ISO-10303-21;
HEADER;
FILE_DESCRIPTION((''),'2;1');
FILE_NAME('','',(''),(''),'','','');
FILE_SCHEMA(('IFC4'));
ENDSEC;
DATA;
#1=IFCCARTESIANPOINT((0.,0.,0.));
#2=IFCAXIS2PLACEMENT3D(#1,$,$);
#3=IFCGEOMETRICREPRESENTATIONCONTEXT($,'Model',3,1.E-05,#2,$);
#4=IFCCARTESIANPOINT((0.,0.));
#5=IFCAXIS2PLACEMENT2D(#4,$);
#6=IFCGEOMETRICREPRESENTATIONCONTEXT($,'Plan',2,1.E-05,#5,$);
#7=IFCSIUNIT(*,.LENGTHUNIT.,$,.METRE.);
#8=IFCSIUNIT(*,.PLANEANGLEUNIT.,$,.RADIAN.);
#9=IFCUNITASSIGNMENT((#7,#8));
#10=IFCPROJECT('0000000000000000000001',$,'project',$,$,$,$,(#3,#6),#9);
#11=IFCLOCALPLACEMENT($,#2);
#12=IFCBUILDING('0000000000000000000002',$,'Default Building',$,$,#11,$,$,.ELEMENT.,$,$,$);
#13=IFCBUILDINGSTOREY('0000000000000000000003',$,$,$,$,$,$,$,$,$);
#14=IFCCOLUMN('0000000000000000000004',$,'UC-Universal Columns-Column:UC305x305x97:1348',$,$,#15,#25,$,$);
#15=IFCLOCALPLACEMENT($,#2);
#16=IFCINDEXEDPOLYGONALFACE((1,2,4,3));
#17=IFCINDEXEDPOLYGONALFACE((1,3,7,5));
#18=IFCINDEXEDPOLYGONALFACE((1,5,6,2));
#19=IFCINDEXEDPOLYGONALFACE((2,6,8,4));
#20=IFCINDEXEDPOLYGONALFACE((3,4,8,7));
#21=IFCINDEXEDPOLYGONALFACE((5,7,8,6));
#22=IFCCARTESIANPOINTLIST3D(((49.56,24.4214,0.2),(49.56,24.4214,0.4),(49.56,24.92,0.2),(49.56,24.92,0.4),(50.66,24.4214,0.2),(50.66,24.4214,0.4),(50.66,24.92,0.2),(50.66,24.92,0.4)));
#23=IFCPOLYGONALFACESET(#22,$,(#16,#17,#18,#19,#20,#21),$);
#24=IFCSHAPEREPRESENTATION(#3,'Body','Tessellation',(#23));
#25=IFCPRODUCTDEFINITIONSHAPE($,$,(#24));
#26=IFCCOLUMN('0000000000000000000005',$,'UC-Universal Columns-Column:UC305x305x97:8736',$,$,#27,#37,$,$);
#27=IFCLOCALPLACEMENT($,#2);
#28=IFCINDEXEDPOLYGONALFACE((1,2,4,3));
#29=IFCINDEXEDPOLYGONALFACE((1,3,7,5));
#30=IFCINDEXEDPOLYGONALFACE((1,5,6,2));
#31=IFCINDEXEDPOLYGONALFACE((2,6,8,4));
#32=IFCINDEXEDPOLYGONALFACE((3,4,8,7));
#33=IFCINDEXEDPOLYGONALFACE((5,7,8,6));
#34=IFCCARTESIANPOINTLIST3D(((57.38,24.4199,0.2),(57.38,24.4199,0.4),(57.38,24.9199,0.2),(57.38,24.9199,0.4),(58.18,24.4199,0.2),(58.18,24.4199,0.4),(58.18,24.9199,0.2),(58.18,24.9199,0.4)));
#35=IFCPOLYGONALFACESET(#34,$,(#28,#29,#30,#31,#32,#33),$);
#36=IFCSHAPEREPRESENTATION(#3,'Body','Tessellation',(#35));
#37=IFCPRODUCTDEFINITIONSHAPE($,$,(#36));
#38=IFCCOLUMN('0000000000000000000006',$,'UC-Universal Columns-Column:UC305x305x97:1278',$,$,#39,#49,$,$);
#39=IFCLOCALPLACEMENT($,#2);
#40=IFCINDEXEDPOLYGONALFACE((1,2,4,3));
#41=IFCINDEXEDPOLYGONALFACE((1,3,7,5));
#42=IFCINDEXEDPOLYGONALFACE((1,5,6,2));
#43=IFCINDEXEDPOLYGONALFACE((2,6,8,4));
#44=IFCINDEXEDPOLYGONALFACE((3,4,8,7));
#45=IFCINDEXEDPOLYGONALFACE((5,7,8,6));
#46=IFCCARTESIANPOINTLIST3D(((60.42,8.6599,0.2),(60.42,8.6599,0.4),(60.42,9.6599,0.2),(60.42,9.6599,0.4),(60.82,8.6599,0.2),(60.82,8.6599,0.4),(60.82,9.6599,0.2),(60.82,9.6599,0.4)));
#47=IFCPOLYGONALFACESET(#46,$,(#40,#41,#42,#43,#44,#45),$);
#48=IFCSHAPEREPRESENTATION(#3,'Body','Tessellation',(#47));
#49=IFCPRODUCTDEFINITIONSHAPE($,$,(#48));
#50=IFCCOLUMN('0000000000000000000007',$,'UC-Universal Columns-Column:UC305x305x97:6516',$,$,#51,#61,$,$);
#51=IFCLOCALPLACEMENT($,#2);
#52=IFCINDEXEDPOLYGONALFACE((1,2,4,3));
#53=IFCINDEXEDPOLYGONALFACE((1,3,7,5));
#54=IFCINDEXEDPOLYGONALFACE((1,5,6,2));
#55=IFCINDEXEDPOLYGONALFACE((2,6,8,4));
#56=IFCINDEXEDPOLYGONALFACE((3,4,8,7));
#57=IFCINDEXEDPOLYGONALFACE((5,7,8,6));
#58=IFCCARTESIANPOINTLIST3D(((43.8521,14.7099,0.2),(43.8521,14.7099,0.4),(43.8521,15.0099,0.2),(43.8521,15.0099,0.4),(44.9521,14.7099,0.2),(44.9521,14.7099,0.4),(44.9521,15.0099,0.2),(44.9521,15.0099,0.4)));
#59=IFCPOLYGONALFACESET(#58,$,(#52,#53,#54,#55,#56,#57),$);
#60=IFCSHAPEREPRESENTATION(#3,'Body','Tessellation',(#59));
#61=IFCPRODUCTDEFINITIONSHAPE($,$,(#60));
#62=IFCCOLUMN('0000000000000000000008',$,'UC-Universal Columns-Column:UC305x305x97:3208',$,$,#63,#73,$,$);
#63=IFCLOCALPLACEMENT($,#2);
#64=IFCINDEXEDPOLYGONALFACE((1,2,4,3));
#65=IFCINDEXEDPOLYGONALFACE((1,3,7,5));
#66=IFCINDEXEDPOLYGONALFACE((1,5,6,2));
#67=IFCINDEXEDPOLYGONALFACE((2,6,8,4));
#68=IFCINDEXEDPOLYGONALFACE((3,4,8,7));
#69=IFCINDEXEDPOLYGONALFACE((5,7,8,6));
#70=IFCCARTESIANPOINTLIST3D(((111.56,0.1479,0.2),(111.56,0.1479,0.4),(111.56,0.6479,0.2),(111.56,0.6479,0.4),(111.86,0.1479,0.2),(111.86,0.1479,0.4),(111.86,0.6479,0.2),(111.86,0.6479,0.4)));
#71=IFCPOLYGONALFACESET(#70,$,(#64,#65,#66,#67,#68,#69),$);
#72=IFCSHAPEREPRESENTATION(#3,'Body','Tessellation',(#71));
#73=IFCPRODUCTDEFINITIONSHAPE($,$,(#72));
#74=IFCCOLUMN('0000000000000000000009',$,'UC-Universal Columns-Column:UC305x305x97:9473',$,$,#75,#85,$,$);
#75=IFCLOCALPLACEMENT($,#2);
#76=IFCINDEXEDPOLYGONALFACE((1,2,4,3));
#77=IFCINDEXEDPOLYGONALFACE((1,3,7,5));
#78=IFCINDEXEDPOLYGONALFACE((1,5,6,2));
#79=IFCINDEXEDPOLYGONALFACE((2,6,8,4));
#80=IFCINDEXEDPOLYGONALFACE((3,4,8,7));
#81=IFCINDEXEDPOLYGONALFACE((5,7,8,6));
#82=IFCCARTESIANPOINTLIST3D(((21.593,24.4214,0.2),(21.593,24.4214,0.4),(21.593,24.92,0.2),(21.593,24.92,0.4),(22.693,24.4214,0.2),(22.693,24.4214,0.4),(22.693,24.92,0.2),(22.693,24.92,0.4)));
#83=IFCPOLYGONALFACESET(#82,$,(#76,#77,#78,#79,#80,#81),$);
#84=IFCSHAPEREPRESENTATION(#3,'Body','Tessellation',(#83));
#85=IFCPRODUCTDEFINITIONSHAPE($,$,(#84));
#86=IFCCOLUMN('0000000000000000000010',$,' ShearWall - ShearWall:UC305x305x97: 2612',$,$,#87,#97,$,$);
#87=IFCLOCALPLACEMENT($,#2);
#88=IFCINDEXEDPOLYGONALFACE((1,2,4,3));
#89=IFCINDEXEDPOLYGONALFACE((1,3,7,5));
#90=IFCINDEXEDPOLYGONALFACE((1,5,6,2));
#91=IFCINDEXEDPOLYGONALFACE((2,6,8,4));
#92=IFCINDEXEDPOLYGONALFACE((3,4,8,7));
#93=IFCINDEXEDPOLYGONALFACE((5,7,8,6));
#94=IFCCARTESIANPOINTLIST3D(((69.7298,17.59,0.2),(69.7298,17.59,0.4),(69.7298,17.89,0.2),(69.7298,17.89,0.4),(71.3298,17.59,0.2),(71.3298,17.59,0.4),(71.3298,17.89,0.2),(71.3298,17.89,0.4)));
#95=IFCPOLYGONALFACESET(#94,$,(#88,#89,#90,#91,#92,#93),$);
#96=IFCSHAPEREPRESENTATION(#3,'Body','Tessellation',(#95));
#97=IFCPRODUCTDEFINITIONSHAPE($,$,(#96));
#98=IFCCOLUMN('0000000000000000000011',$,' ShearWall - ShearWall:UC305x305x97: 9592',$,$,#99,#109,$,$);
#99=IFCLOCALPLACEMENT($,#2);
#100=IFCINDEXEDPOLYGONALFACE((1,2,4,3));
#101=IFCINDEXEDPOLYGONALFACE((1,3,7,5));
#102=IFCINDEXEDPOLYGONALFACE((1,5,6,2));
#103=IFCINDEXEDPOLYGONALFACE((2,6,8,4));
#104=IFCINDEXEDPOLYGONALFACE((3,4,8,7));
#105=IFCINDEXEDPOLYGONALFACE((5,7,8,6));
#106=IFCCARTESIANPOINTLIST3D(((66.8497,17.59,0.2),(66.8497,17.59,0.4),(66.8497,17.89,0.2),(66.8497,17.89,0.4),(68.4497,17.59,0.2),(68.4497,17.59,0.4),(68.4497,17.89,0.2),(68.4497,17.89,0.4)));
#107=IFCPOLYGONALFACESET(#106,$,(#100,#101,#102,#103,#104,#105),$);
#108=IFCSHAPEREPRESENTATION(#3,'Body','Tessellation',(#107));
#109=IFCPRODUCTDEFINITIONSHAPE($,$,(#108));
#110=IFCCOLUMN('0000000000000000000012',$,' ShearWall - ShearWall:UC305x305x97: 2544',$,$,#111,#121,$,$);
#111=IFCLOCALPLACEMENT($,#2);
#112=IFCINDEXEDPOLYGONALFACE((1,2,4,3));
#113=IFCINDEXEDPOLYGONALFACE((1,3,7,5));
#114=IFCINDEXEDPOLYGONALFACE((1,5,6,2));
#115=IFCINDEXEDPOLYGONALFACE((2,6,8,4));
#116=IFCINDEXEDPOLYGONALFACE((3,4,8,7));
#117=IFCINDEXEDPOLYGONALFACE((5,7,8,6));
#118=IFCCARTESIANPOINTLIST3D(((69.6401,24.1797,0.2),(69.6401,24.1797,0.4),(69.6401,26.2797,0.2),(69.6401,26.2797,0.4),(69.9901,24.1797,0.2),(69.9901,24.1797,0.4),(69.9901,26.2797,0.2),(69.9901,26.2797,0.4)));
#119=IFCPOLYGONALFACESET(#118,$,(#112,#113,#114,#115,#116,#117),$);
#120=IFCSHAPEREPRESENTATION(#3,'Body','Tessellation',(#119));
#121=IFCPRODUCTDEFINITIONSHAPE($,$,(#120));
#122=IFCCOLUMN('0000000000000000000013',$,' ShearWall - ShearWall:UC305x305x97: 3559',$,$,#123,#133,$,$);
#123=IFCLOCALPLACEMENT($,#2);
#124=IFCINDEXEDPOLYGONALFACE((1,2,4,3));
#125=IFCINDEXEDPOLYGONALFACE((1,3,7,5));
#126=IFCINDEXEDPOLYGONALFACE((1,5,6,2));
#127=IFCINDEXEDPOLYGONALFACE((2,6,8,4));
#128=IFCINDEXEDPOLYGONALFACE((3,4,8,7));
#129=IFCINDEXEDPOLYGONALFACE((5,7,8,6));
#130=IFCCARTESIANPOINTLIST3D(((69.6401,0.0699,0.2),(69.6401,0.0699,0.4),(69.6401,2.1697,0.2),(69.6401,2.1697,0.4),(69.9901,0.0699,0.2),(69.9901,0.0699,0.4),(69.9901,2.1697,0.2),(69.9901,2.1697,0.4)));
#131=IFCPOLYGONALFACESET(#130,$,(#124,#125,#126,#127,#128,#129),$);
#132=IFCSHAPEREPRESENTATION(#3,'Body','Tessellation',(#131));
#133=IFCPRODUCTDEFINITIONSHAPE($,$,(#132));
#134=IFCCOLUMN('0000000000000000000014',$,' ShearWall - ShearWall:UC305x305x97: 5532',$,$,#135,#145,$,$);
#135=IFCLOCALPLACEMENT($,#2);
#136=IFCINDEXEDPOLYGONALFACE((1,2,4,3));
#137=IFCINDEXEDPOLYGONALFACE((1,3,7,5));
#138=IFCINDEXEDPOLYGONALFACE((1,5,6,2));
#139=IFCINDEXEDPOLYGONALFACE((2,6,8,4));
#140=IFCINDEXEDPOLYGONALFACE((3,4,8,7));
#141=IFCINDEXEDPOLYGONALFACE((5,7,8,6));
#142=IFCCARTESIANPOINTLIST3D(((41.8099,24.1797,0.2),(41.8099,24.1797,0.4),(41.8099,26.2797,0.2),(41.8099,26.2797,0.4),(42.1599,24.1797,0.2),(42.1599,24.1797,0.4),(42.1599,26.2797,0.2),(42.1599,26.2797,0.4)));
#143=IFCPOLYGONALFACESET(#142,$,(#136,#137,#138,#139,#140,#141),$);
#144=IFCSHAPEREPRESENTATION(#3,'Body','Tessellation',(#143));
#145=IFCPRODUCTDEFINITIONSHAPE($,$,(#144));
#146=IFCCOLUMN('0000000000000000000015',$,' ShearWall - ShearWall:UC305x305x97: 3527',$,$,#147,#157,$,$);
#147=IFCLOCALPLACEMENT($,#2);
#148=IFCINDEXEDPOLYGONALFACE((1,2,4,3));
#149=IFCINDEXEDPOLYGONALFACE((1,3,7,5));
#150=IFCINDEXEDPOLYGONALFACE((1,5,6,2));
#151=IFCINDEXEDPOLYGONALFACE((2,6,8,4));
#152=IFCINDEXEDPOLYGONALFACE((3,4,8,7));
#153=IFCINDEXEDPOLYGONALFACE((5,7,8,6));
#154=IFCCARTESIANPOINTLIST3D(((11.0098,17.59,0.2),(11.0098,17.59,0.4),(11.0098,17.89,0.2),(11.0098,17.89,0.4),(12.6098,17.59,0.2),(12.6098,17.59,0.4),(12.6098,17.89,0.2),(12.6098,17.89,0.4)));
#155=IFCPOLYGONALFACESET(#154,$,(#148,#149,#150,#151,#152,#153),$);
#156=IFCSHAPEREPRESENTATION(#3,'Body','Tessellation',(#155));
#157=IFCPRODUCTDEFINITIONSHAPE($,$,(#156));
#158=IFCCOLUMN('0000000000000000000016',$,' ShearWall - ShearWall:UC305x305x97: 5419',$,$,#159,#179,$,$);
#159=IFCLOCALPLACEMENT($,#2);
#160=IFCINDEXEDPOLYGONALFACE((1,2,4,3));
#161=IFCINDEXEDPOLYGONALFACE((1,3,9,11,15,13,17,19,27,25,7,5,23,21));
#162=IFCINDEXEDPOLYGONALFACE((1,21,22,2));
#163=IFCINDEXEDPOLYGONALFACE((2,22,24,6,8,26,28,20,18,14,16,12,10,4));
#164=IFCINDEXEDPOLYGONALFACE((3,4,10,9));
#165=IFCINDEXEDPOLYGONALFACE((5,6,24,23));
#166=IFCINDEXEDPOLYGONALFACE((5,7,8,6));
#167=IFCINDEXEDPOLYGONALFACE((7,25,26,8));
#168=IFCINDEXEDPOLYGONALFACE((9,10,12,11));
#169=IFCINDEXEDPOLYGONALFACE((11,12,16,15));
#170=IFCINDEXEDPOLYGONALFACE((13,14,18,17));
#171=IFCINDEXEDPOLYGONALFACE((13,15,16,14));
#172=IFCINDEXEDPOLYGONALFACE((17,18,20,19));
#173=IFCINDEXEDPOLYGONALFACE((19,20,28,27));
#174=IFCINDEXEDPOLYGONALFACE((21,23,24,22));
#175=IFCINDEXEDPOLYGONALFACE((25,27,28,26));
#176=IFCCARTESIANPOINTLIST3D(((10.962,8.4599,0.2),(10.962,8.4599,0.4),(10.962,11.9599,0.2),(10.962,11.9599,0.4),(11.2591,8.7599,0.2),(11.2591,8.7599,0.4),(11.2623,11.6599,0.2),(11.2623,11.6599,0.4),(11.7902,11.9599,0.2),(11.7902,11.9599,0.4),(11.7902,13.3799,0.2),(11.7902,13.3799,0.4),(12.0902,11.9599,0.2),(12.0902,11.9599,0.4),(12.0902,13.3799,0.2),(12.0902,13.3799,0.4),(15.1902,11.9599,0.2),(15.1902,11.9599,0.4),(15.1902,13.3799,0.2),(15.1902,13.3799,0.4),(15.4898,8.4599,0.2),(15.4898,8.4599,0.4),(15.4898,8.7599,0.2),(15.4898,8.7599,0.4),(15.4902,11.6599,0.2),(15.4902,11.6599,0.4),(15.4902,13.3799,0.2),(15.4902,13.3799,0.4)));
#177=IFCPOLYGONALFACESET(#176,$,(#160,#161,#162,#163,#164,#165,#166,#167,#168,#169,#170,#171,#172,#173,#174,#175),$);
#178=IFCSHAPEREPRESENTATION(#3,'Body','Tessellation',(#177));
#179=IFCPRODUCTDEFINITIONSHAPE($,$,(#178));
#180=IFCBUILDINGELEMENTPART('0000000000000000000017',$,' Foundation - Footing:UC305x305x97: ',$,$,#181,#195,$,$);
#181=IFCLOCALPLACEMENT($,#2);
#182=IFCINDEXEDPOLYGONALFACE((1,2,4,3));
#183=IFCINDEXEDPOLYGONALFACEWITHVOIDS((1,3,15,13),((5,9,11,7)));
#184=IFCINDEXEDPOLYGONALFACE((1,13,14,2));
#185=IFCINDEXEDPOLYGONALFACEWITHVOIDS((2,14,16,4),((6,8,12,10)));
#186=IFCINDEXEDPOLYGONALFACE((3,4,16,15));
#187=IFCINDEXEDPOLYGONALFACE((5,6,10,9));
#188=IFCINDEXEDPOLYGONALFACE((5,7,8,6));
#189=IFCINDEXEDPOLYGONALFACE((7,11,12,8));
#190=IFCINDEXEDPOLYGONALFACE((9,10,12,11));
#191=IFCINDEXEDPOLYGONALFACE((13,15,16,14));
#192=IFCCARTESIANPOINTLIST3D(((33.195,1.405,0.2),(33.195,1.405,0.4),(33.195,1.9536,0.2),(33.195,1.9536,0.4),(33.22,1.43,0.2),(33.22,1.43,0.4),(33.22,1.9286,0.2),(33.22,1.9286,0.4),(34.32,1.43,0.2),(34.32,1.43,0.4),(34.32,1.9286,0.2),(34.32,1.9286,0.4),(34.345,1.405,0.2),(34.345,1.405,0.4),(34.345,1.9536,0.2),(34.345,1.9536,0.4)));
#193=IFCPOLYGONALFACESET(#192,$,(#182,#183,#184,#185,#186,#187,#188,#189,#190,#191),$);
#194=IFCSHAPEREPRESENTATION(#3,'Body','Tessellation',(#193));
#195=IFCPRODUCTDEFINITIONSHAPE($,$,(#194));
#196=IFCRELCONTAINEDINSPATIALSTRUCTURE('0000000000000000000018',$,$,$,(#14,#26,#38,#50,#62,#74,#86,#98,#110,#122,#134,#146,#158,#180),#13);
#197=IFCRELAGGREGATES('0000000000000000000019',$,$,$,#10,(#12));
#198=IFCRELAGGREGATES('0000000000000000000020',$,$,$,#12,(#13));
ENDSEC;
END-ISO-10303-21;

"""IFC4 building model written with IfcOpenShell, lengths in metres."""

from ifc_helpers import new_model, si_unit, origin, origin_with_axes, origin_2d, place, context, project, spatial, polyline, outline, extrude, element, save


model = new_model("IFC4")

# Units and contexts
model_context = context("Model", 3, precision=1e-05, world=origin())
plan_context = context("Plan", 2, precision=1e-05, world=origin_2d())
ifc_project = project(units=[si_unit("LENGTHUNIT", "METRE"), si_unit("PLANEANGLEUNIT", "RADIAN")], contexts=[model_context, plan_context])

# Building, storey
building_placement = place(None, origin())
building = spatial("IfcBuilding", under=ifc_project, at=building_placement, Name="Default Building", CompositionType="ELEMENT")
storey = spatial("IfcBuildingStorey", under=building)

# Columns
element("IfcColumn", 1, inside=storey, Name="UC-Universal Columns-Column:UC305x305x97:1348", context=model_context, shape_type="SweptSolid", body=[
    extrude(outline(polyline([(50.66, 24.4214, 0.2), (49.56, 24.4214, 0.2), (49.56, 24.92, 0.2), (50.66, 24.92, 0.2), (50.66, 24.4214, 0.2)])), None, (0.0, 0.0, 1.0), 0.2),
])
element("IfcColumn", 2, inside=storey, Name="UC-Universal Columns-Column:UC305x305x97:8736", context=model_context, shape_type="SweptSolid", body=[
    extrude(outline(polyline([(57.38, 24.4199, 0.2), (58.18, 24.4199, 0.2), (58.18, 24.9199, 0.2), (57.38, 24.9199, 0.2), (57.38, 24.4199, 0.2)])), None, (0.0, 0.0, 1.0), 0.2),
])
element("IfcColumn", 3, inside=storey, Name="UC-Universal Columns-Column:UC305x305x97:1278", context=model_context, shape_type="SweptSolid", body=[
    extrude(outline(polyline([(60.42, 8.6599, 0.2), (60.82, 8.6599, 0.2), (60.82, 9.6599, 0.2), (60.42, 9.6599, 0.2), (60.42, 8.6599, 0.2)])), None, (0.0, 0.0, 1.0), 0.2),
])
element("IfcColumn", 4, inside=storey, Name="UC-Universal Columns-Column:UC305x305x97:6516", context=model_context, shape_type="SweptSolid", body=[
    extrude(outline(polyline([(44.9521, 14.7099, 0.2), (44.9521, 15.0099, 0.2), (43.8521, 15.0099, 0.2), (43.8521, 14.7099, 0.2), (44.9521, 14.7099, 0.2)])), None, (0.0, 0.0, 1.0), 0.2),
])
element("IfcColumn", 5, inside=storey, Name="UC-Universal Columns-Column:UC305x305x97:3208", context=model_context, shape_type="SweptSolid", body=[
    extrude(outline(polyline([(111.56, 0.6479, 0.2), (111.86, 0.6479, 0.2), (111.86, 0.1479, 0.2), (111.56, 0.1479, 0.2), (111.56, 0.6479, 0.2)])), None, (0.0, 0.0, 1.0), 0.2),
])
element("IfcColumn", 6, inside=storey, Name="UC-Universal Columns-Column:UC305x305x97:9473", context=model_context, shape_type="SweptSolid", body=[
    extrude(outline(polyline([(21.593, 24.4214, 0.2), (22.693, 24.4214, 0.2), (22.693, 24.92, 0.2), (21.593, 24.92, 0.2), (21.593, 24.4214, 0.2)])), None, (0.0, 0.0, 1.0), 0.2),
])
column_1_placement = place(None, origin_with_axes())
element("IfcColumn", 7, at=column_1_placement, inside=storey, Name=" ShearWall - ShearWall:UC305x305x97: 2612", context=model_context, shape_type="SweptSolid", body=[
    extrude(outline(polyline([(69.7298, 17.59, 0.2), (69.7298, 17.89, 0.2), (71.3298, 17.89, 0.2), (71.3298, 17.59, 0.2), (69.7298, 17.59, 0.2)])), None, (0.0, 0.0, 1.0), 0.2),
])
column_2_placement = place(None, origin_with_axes())
element("IfcColumn", 8, at=column_2_placement, inside=storey, Name=" ShearWall - ShearWall:UC305x305x97: 9592", context=model_context, shape_type="SweptSolid", body=[
    extrude(outline(polyline([(66.8497, 17.59, 0.2), (66.8497, 17.89, 0.2), (68.4497, 17.89, 0.2), (68.4497, 17.59, 0.2), (66.8497, 17.59, 0.2)])), None, (0.0, 0.0, 1.0), 0.2),
])
column_3_placement = place(None, origin_with_axes())
element("IfcColumn", 9, at=column_3_placement, inside=storey, Name=" ShearWall - ShearWall:UC305x305x97: 2544", context=model_context, shape_type="SweptSolid", body=[
    extrude(outline(polyline([(69.9901, 26.2797, 0.2), (69.6401, 26.2797, 0.2), (69.6401, 24.1797, 0.2), (69.9901, 24.1797, 0.2), (69.9901, 26.2797, 0.2)])), None, (0.0, 0.0, 1.0), 0.2),
])
column_4_placement = place(None, origin_with_axes())
element("IfcColumn", 10, at=column_4_placement, inside=storey, Name=" ShearWall - ShearWall:UC305x305x97: 3559", context=model_context, shape_type="SweptSolid", body=[
    extrude(outline(polyline([(69.9901, 2.1697, 0.2), (69.6401, 2.1697, 0.2), (69.6401, 0.0699, 0.2), (69.9901, 0.0699, 0.2), (69.9901, 2.1697, 0.2)])), None, (0.0, 0.0, 1.0), 0.2),
])
column_5_placement = place(None, origin_with_axes())
element("IfcColumn", 11, at=column_5_placement, inside=storey, Name=" ShearWall - ShearWall:UC305x305x97: 5532", context=model_context, shape_type="SweptSolid", body=[
    extrude(outline(polyline([(41.8099, 26.2797, 0.2), (42.1599, 26.2797, 0.2), (42.1599, 24.1797, 0.2), (41.8099, 24.1797, 0.2), (41.8099, 26.2797, 0.2)])), None, (0.0, 0.0, 1.0), 0.2),
])
column_6_placement = place(None, origin_with_axes())
element("IfcColumn", 12, at=column_6_placement, inside=storey, Name=" ShearWall - ShearWall:UC305x305x97: 3527", context=model_context, shape_type="SweptSolid", body=[
    extrude(outline(polyline([(11.0098, 17.59, 0.2), (11.0098, 17.89, 0.2), (12.6098, 17.89, 0.2), (12.6098, 17.59, 0.2), (11.0098, 17.59, 0.2)])), None, (0.0, 0.0, 1.0), 0.2),
])
column_7_placement = place(None, origin_with_axes())
element("IfcColumn", 13, at=column_7_placement, inside=storey, Name=" ShearWall - ShearWall:UC305x305x97: 5419", context=model_context, shape_type="SweptSolid", body=[
    extrude(outline(polyline([(10.962, 8.4599, 0.2), (15.4898, 8.4599, 0.2), (15.4898, 8.7599, 0.2), (11.2591, 8.7599, 0.2), (11.2623, 11.6599, 0.2), (15.4902, 11.6599, 0.2), (15.4902, 13.3799, 0.2), (15.1902, 13.3799, 0.2), (15.1902, 11.9599, 0.2), (12.0902, 11.9599, 0.2), (12.0902, 13.3799, 0.2), (11.7902, 13.3799, 0.2), (11.7902, 11.9599, 0.2), (10.962, 11.9599, 0.2), (10.962, 8.4599, 0.2)])), None, (0.0, 0.0, 1.0), 0.2),
])

# Building element part, opening
building_element_part_1 = element("IfcBuildingElementPart", 14, inside=storey, Name=" Foundation - Footing:UC305x305x97: ", context=model_context, shape_type="SweptSolid", body=[
    extrude(outline(polyline([(34.345, 1.405, 0.2), (33.195, 1.405, 0.2), (33.195, 1.9536, 0.2), (34.345, 1.9536, 0.2), (34.345, 1.405, 0.2)])), None, (0.0, 0.0, 1.0), 0.2),
])
element("IfcOpeningElement", 15, inside=storey, cuts=building_element_part_1, context=model_context, shape_type="SweptSolid", body=[
    extrude(outline(polyline([(34.32, 1.43, 0.2), (33.22, 1.43, 0.2), (33.22, 1.9286, 0.2), (34.32, 1.9286, 0.2), (34.32, 1.43, 0.2)])), None, (0.0, 0.0, 1.0), 0.2),
])

save(model, "model.ifc")
